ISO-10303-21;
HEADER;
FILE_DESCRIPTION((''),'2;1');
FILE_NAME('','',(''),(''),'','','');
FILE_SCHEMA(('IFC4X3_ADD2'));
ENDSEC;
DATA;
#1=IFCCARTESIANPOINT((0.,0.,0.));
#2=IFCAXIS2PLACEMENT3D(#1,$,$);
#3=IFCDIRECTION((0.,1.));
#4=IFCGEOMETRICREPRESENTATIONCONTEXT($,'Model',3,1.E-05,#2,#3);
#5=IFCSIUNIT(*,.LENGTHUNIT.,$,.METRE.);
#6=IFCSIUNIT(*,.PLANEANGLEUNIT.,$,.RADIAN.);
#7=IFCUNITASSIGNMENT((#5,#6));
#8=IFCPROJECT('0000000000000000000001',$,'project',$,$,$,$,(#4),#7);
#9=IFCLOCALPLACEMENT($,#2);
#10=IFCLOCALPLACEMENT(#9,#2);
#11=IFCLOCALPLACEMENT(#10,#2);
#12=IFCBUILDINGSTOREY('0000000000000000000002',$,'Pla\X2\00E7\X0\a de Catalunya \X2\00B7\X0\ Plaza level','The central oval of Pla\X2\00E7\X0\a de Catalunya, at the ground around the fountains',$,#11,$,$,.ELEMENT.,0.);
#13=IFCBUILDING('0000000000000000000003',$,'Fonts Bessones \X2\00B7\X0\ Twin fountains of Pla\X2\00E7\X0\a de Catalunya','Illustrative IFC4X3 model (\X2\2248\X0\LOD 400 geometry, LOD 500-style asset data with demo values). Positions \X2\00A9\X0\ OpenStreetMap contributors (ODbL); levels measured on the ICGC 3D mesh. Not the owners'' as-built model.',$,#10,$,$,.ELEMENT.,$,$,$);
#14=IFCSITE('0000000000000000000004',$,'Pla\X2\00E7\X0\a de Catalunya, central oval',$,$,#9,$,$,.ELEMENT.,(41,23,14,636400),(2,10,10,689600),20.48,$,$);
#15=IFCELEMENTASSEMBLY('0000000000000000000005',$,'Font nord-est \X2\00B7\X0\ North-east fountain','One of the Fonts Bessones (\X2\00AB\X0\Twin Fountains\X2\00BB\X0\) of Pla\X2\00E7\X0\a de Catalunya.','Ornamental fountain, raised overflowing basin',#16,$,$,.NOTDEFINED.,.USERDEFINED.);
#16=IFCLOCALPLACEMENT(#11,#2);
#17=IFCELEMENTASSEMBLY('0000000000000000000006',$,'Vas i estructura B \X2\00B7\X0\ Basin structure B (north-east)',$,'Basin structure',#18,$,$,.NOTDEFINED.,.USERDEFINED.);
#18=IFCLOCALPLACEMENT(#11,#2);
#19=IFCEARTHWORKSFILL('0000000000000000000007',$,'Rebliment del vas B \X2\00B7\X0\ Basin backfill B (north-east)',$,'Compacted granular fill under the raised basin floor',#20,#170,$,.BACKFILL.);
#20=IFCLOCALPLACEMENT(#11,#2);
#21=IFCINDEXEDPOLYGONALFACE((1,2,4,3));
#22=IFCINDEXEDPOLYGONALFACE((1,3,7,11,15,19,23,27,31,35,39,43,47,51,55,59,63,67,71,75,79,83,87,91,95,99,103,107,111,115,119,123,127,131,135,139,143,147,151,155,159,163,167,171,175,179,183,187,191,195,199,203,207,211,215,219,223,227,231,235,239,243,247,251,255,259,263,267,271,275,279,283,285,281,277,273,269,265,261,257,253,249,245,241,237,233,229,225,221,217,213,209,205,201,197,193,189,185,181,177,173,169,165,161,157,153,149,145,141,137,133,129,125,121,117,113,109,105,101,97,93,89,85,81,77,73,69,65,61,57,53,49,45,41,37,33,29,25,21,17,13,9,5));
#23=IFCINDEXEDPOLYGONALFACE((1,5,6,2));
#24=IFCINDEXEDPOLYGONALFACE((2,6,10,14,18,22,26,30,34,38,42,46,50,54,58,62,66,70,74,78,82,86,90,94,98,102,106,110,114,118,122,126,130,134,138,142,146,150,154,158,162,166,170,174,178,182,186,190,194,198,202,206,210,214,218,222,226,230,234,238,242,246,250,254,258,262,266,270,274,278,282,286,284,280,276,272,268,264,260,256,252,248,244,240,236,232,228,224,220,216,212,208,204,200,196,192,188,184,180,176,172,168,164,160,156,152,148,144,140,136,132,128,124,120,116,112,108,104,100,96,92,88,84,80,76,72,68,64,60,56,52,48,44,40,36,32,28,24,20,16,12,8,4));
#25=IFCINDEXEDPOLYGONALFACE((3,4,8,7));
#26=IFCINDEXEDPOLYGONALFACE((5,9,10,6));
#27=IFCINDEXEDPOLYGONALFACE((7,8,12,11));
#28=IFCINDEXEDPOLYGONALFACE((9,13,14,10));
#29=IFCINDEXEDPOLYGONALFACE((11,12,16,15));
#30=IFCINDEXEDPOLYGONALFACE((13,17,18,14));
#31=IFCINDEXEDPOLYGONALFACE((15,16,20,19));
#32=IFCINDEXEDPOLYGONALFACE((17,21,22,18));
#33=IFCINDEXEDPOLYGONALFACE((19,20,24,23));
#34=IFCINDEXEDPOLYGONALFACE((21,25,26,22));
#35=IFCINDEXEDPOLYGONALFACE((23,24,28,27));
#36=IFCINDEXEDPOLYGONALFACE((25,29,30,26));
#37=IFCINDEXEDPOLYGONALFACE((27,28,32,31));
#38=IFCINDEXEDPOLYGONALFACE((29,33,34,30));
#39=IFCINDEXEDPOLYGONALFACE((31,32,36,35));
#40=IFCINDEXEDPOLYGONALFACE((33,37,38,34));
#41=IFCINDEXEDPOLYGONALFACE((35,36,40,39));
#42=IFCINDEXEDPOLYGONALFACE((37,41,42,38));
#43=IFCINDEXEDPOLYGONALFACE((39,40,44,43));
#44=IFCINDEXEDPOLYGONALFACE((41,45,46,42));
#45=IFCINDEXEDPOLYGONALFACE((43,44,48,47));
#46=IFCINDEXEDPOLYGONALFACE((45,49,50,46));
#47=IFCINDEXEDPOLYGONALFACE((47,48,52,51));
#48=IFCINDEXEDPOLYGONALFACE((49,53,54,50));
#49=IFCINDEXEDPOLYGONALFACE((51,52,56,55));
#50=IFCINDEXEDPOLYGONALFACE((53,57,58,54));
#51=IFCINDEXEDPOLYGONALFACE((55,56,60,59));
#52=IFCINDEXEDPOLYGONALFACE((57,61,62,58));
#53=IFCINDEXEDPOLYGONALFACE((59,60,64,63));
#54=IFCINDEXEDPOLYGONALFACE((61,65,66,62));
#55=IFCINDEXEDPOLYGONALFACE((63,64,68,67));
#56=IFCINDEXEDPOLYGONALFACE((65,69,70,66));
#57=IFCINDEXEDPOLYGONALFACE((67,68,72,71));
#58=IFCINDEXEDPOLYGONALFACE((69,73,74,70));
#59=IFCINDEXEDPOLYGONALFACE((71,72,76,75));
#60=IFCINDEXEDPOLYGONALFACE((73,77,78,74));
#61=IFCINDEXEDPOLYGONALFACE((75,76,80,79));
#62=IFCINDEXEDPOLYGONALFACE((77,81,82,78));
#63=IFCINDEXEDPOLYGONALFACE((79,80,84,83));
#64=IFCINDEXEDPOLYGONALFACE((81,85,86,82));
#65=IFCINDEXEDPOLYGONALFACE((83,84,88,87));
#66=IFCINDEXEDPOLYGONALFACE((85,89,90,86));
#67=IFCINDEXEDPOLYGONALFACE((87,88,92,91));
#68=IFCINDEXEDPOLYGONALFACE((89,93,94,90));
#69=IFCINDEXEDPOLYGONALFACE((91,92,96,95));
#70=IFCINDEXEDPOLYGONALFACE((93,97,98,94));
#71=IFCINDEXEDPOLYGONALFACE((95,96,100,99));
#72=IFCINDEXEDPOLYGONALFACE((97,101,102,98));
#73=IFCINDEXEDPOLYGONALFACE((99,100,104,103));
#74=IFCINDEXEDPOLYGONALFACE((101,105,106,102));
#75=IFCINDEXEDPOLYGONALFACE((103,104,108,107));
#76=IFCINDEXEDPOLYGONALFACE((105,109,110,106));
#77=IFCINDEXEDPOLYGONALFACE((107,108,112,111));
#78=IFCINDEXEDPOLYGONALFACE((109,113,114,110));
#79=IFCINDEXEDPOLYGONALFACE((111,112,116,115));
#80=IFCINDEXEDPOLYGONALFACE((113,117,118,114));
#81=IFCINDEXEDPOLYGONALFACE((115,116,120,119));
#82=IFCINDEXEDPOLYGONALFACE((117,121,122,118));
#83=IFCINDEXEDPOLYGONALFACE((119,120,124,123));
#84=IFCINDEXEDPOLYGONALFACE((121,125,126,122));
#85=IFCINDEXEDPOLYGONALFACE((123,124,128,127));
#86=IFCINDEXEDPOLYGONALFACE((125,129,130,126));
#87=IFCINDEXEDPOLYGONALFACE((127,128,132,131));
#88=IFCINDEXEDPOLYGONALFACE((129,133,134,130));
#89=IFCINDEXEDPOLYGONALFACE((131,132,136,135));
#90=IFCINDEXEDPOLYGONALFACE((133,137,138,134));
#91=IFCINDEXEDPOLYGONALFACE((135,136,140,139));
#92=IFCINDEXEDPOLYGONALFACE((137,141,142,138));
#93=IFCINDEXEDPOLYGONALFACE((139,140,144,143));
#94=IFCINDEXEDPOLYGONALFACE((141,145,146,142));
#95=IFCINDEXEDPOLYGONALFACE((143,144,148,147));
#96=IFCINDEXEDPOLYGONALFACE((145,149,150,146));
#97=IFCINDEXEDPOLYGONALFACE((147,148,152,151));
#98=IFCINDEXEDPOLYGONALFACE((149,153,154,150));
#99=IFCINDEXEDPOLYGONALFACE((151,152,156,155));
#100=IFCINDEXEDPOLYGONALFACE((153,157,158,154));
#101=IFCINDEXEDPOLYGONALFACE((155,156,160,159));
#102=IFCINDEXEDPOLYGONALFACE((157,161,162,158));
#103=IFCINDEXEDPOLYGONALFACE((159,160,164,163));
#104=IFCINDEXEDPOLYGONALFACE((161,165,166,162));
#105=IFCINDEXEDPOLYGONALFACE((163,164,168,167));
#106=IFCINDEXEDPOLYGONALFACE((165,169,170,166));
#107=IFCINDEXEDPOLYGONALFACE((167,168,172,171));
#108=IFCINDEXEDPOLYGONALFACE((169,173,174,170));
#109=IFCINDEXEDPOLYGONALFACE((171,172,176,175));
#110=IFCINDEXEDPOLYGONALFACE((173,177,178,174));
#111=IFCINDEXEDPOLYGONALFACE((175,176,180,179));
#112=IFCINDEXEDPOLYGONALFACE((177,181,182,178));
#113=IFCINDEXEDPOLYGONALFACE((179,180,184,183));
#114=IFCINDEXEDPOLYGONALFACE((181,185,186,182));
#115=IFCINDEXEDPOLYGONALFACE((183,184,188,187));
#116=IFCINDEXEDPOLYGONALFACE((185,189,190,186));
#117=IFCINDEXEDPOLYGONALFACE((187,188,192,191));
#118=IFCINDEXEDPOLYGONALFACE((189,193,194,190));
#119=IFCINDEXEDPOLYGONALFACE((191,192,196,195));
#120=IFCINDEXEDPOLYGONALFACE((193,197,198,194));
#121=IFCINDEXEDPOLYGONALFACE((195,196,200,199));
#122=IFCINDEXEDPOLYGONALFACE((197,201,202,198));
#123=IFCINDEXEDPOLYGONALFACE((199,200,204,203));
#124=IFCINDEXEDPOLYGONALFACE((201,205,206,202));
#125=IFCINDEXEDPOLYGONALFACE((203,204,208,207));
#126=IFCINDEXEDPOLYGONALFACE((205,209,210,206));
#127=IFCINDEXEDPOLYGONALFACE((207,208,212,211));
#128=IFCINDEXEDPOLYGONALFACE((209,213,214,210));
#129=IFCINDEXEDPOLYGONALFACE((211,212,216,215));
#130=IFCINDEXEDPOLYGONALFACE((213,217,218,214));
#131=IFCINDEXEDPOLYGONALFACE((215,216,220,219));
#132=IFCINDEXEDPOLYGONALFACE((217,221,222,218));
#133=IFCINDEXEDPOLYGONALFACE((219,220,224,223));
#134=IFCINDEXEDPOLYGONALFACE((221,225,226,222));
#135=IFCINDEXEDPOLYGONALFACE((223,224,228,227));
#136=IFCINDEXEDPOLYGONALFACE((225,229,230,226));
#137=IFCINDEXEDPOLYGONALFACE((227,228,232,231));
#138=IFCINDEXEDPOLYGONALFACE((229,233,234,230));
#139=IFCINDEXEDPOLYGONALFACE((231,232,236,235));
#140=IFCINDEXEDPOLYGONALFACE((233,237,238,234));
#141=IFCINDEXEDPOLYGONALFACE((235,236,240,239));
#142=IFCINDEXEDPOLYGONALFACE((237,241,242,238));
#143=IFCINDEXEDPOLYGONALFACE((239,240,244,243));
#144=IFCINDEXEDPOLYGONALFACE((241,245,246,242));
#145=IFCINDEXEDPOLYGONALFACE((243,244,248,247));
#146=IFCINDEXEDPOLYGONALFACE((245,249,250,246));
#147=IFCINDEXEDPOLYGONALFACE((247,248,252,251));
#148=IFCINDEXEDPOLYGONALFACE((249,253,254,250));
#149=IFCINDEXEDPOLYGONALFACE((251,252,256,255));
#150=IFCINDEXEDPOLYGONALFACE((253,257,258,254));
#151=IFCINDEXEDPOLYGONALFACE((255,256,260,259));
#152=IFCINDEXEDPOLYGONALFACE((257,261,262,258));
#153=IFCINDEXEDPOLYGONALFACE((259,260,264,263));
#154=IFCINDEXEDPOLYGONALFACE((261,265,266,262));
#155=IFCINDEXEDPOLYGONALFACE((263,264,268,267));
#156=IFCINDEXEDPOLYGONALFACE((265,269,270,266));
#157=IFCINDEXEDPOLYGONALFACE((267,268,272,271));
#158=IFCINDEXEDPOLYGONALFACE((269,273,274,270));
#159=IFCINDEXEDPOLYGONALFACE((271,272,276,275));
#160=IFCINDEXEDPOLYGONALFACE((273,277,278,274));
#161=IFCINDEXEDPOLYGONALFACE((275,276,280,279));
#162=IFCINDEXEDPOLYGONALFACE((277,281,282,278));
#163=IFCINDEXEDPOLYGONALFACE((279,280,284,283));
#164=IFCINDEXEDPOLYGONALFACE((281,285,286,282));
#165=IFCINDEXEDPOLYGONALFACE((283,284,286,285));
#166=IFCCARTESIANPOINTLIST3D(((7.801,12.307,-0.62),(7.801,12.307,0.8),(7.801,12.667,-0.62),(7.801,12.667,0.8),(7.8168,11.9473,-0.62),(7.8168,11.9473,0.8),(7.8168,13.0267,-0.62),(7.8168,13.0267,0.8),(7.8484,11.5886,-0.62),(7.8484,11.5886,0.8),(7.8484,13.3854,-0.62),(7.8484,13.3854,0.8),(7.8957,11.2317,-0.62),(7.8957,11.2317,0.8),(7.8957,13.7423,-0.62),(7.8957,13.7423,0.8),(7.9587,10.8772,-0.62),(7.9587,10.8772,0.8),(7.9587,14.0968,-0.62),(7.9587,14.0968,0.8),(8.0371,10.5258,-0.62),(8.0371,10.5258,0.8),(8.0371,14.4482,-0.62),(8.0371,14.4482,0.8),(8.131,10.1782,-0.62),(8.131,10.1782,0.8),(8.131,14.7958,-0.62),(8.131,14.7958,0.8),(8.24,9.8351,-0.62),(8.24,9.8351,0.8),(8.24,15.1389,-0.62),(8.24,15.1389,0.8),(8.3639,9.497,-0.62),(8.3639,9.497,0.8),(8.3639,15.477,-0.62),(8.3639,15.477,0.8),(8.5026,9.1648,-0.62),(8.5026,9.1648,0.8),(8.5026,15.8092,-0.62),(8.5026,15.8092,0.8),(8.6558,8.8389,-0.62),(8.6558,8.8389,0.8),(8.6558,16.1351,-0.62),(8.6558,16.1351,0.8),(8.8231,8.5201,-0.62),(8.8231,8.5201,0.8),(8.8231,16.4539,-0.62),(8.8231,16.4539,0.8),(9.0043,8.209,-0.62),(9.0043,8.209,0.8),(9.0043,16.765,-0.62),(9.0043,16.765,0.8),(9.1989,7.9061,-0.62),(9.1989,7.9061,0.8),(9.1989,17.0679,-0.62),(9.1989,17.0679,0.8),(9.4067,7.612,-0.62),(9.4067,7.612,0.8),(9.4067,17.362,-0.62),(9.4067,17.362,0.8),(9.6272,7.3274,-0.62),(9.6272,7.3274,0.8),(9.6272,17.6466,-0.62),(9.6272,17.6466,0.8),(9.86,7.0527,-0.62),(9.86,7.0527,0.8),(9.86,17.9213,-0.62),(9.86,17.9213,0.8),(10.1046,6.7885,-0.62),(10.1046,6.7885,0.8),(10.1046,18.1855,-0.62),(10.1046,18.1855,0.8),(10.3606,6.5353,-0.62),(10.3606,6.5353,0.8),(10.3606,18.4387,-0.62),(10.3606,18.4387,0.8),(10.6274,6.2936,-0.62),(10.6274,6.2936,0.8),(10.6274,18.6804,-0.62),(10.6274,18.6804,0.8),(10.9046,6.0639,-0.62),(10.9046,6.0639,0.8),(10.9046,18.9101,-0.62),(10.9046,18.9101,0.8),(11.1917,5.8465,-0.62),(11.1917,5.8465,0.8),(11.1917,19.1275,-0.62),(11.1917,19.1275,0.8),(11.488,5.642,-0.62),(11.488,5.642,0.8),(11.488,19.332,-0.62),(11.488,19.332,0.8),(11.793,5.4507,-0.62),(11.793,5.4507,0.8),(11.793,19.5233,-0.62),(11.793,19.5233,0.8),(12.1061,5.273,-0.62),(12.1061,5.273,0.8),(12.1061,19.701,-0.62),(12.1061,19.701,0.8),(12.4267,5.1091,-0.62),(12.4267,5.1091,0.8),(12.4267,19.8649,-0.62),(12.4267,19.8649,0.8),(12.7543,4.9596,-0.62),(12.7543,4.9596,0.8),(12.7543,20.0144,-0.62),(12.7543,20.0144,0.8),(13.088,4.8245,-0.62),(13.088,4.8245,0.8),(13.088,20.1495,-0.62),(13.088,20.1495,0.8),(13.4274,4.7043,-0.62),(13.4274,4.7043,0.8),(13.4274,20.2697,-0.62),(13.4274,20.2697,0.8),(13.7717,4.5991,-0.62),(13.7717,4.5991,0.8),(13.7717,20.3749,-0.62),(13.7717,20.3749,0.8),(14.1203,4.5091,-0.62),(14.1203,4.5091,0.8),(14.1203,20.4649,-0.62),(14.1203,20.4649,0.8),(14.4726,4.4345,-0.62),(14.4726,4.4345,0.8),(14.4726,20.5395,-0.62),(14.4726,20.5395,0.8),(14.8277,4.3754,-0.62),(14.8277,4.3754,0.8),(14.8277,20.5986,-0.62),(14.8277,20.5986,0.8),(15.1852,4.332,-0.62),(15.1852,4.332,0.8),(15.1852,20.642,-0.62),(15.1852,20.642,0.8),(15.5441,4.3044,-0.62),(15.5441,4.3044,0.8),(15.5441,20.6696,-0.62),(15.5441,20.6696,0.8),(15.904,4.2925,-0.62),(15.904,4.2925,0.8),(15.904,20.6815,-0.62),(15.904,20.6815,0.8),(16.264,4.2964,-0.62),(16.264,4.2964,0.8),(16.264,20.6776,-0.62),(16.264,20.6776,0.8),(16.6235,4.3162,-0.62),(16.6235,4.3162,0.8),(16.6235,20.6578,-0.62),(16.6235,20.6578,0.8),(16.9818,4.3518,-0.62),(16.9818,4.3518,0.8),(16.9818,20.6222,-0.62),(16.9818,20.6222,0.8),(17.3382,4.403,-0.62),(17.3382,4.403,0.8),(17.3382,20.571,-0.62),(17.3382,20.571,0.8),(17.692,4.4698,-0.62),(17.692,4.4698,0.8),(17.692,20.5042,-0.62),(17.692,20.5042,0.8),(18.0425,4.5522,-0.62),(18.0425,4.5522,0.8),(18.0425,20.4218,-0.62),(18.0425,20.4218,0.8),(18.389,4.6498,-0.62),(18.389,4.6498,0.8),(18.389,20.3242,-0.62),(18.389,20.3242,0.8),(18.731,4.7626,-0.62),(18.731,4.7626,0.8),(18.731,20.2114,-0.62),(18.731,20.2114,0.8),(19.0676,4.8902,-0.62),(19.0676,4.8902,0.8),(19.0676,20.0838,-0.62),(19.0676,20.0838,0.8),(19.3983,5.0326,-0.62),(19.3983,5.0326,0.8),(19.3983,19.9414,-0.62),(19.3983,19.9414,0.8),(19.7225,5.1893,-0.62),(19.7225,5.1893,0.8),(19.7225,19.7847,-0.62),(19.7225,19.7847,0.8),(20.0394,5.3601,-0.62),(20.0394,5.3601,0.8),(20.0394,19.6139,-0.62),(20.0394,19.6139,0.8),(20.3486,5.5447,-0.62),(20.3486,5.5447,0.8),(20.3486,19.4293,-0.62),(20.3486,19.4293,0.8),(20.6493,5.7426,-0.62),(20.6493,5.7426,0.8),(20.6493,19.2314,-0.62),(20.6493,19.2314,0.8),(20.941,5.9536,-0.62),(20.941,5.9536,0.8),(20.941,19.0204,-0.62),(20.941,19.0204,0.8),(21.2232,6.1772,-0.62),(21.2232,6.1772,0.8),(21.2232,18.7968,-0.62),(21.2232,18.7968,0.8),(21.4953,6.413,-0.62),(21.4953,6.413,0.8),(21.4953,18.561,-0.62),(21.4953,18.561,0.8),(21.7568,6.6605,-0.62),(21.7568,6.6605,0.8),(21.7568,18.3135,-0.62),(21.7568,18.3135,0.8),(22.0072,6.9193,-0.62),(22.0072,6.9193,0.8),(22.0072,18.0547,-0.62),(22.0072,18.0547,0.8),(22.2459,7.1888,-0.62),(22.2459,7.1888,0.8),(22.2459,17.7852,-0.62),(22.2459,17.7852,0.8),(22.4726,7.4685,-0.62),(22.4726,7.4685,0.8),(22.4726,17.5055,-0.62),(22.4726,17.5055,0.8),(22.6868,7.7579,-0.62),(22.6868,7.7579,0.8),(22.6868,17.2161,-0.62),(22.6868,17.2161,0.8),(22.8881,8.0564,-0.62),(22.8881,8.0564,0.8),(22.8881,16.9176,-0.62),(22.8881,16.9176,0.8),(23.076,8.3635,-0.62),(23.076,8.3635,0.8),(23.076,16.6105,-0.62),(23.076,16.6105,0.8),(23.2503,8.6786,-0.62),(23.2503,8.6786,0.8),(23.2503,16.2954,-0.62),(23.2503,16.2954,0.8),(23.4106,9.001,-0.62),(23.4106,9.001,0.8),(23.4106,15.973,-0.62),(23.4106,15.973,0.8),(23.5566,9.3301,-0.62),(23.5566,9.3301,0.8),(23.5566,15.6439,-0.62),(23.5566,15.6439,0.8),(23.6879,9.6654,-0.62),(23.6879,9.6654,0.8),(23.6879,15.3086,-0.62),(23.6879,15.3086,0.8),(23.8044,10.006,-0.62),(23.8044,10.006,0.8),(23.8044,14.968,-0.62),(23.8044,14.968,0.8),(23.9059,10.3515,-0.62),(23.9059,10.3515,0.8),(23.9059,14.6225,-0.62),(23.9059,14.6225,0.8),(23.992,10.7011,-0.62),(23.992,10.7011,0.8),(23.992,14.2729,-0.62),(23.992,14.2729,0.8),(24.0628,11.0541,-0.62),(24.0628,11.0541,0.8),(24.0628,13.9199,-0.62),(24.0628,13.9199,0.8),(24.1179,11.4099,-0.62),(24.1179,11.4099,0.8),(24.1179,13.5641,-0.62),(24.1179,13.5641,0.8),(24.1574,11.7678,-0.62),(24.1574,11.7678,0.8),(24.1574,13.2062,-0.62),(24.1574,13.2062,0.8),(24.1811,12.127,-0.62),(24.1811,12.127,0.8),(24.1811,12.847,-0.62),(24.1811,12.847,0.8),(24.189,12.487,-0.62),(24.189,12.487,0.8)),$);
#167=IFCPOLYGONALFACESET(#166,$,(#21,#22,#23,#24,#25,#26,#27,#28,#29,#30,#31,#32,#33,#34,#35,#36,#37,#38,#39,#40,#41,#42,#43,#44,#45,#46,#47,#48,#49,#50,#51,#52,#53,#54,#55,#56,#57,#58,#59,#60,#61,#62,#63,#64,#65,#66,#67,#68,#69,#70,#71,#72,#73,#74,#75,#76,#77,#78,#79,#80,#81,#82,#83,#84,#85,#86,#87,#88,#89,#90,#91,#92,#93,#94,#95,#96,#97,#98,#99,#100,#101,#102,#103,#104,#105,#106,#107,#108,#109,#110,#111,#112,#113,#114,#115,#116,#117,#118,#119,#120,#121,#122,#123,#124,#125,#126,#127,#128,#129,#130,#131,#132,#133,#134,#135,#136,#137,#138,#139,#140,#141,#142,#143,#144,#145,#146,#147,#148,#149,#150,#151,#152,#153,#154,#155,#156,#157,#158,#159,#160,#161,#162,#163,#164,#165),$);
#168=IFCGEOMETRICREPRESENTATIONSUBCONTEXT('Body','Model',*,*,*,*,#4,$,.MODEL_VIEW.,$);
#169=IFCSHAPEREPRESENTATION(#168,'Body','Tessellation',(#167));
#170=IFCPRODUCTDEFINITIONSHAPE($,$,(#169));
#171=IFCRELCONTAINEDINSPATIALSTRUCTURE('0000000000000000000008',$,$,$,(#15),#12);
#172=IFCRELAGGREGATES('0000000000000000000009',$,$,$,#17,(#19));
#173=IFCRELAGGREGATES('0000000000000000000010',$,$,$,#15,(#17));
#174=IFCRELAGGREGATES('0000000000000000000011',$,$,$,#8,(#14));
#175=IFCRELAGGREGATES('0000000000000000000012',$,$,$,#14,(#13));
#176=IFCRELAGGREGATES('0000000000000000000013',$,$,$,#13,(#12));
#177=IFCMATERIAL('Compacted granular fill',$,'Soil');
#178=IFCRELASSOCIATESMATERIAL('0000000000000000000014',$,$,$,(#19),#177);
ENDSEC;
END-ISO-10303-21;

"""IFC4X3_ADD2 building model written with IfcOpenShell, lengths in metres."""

from ifc_helpers import new_model, si_unit, direction, frame, origin, origin_2d_with_axis, place, context, subcontext, project, spatial, circle, extrude, material, element, aggregate, save


model = new_model("IFC4X3_ADD2")

# Units and contexts
model_context = context("Model", 3, precision=1e-05, world=origin(), true_north=direction((0.0, 1.0)))
body_context = subcontext(model_context, "Body", "Model", "MODEL_VIEW")
ifc_project = project(units=[si_unit("LENGTHUNIT", "METRE"), si_unit("PLANEANGLEUNIT", "RADIAN")], contexts=[model_context])

# Site, building, storey
site_placement = place(None, origin())
site = spatial("IfcSite", under=ifc_project, at=site_placement, Name="Plaça de Catalunya, central oval", CompositionType="ELEMENT", RefLatitude=(41, 23, 14, 636400), RefLongitude=(2, 10, 10, 689600), RefElevation=20.48)
building_placement = place(site_placement, origin())
building = spatial("IfcBuilding", under=site, at=building_placement, Name="Fonts Bessones · Twin fountains of Plaça de Catalunya", Description="Illustrative IFC4X3 model (≈LOD 400 geometry, LOD 500-style asset data with demo values). Positions © OpenStreetMap contributors (ODbL); levels measured on the ICGC 3D mesh. Not the owners' as-built model.", CompositionType="ELEMENT")
storey_placement = place(building_placement, origin())
storey = spatial("IfcBuildingStorey", under=building, at=storey_placement, Name="Plaça de Catalunya · Plaza level", Description="The central oval of Plaça de Catalunya, at the ground around the fountains", CompositionType="ELEMENT", Elevation=0.0)

# Element assemblies
assembly_1_placement = place(building_placement, origin())
assembly_1 = element("IfcElementAssembly", 1, at=assembly_1_placement, inside=storey, Name="Font nord-est · North-east fountain", Description="One of the Fonts Bessones («Twin Fountains») of Plaça de Catalunya.", ObjectType="Ornamental fountain, raised overflowing basin", AssemblyPlace="NOTDEFINED", PredefinedType="USERDEFINED")
assembly_2_placement = place(building_placement, origin())
assembly_2 = element("IfcElementAssembly", 2, at=assembly_2_placement, Name="Vas i estructura B · Basin structure B (north-east)", ObjectType="Basin structure", AssemblyPlace="NOTDEFINED", PredefinedType="USERDEFINED")

# Earthworks fill
ifc_material_1 = material(Name="Compacted granular fill", Category="Soil")
earthworks_fill_placement = place(building_placement, origin())
earthworks_fill = element("IfcEarthworksFill", 3, at=earthworks_fill_placement, material=ifc_material_1, Name="Rebliment del vas B · Basin backfill B (north-east)", ObjectType="Compacted granular fill under the raised basin floor", PredefinedType="BACKFILL", context=body_context, shape_type="SweptSolid", body=[
    extrude(circle(Radius=8.195, at=origin_2d_with_axis()), frame((15.994, 12.487, -0.62)), (0.0, 0.0, 1.0), 1.42),
])
aggregate(assembly_2, [earthworks_fill])

aggregate(assembly_1, [assembly_2])

save(model, "model.ifc")
